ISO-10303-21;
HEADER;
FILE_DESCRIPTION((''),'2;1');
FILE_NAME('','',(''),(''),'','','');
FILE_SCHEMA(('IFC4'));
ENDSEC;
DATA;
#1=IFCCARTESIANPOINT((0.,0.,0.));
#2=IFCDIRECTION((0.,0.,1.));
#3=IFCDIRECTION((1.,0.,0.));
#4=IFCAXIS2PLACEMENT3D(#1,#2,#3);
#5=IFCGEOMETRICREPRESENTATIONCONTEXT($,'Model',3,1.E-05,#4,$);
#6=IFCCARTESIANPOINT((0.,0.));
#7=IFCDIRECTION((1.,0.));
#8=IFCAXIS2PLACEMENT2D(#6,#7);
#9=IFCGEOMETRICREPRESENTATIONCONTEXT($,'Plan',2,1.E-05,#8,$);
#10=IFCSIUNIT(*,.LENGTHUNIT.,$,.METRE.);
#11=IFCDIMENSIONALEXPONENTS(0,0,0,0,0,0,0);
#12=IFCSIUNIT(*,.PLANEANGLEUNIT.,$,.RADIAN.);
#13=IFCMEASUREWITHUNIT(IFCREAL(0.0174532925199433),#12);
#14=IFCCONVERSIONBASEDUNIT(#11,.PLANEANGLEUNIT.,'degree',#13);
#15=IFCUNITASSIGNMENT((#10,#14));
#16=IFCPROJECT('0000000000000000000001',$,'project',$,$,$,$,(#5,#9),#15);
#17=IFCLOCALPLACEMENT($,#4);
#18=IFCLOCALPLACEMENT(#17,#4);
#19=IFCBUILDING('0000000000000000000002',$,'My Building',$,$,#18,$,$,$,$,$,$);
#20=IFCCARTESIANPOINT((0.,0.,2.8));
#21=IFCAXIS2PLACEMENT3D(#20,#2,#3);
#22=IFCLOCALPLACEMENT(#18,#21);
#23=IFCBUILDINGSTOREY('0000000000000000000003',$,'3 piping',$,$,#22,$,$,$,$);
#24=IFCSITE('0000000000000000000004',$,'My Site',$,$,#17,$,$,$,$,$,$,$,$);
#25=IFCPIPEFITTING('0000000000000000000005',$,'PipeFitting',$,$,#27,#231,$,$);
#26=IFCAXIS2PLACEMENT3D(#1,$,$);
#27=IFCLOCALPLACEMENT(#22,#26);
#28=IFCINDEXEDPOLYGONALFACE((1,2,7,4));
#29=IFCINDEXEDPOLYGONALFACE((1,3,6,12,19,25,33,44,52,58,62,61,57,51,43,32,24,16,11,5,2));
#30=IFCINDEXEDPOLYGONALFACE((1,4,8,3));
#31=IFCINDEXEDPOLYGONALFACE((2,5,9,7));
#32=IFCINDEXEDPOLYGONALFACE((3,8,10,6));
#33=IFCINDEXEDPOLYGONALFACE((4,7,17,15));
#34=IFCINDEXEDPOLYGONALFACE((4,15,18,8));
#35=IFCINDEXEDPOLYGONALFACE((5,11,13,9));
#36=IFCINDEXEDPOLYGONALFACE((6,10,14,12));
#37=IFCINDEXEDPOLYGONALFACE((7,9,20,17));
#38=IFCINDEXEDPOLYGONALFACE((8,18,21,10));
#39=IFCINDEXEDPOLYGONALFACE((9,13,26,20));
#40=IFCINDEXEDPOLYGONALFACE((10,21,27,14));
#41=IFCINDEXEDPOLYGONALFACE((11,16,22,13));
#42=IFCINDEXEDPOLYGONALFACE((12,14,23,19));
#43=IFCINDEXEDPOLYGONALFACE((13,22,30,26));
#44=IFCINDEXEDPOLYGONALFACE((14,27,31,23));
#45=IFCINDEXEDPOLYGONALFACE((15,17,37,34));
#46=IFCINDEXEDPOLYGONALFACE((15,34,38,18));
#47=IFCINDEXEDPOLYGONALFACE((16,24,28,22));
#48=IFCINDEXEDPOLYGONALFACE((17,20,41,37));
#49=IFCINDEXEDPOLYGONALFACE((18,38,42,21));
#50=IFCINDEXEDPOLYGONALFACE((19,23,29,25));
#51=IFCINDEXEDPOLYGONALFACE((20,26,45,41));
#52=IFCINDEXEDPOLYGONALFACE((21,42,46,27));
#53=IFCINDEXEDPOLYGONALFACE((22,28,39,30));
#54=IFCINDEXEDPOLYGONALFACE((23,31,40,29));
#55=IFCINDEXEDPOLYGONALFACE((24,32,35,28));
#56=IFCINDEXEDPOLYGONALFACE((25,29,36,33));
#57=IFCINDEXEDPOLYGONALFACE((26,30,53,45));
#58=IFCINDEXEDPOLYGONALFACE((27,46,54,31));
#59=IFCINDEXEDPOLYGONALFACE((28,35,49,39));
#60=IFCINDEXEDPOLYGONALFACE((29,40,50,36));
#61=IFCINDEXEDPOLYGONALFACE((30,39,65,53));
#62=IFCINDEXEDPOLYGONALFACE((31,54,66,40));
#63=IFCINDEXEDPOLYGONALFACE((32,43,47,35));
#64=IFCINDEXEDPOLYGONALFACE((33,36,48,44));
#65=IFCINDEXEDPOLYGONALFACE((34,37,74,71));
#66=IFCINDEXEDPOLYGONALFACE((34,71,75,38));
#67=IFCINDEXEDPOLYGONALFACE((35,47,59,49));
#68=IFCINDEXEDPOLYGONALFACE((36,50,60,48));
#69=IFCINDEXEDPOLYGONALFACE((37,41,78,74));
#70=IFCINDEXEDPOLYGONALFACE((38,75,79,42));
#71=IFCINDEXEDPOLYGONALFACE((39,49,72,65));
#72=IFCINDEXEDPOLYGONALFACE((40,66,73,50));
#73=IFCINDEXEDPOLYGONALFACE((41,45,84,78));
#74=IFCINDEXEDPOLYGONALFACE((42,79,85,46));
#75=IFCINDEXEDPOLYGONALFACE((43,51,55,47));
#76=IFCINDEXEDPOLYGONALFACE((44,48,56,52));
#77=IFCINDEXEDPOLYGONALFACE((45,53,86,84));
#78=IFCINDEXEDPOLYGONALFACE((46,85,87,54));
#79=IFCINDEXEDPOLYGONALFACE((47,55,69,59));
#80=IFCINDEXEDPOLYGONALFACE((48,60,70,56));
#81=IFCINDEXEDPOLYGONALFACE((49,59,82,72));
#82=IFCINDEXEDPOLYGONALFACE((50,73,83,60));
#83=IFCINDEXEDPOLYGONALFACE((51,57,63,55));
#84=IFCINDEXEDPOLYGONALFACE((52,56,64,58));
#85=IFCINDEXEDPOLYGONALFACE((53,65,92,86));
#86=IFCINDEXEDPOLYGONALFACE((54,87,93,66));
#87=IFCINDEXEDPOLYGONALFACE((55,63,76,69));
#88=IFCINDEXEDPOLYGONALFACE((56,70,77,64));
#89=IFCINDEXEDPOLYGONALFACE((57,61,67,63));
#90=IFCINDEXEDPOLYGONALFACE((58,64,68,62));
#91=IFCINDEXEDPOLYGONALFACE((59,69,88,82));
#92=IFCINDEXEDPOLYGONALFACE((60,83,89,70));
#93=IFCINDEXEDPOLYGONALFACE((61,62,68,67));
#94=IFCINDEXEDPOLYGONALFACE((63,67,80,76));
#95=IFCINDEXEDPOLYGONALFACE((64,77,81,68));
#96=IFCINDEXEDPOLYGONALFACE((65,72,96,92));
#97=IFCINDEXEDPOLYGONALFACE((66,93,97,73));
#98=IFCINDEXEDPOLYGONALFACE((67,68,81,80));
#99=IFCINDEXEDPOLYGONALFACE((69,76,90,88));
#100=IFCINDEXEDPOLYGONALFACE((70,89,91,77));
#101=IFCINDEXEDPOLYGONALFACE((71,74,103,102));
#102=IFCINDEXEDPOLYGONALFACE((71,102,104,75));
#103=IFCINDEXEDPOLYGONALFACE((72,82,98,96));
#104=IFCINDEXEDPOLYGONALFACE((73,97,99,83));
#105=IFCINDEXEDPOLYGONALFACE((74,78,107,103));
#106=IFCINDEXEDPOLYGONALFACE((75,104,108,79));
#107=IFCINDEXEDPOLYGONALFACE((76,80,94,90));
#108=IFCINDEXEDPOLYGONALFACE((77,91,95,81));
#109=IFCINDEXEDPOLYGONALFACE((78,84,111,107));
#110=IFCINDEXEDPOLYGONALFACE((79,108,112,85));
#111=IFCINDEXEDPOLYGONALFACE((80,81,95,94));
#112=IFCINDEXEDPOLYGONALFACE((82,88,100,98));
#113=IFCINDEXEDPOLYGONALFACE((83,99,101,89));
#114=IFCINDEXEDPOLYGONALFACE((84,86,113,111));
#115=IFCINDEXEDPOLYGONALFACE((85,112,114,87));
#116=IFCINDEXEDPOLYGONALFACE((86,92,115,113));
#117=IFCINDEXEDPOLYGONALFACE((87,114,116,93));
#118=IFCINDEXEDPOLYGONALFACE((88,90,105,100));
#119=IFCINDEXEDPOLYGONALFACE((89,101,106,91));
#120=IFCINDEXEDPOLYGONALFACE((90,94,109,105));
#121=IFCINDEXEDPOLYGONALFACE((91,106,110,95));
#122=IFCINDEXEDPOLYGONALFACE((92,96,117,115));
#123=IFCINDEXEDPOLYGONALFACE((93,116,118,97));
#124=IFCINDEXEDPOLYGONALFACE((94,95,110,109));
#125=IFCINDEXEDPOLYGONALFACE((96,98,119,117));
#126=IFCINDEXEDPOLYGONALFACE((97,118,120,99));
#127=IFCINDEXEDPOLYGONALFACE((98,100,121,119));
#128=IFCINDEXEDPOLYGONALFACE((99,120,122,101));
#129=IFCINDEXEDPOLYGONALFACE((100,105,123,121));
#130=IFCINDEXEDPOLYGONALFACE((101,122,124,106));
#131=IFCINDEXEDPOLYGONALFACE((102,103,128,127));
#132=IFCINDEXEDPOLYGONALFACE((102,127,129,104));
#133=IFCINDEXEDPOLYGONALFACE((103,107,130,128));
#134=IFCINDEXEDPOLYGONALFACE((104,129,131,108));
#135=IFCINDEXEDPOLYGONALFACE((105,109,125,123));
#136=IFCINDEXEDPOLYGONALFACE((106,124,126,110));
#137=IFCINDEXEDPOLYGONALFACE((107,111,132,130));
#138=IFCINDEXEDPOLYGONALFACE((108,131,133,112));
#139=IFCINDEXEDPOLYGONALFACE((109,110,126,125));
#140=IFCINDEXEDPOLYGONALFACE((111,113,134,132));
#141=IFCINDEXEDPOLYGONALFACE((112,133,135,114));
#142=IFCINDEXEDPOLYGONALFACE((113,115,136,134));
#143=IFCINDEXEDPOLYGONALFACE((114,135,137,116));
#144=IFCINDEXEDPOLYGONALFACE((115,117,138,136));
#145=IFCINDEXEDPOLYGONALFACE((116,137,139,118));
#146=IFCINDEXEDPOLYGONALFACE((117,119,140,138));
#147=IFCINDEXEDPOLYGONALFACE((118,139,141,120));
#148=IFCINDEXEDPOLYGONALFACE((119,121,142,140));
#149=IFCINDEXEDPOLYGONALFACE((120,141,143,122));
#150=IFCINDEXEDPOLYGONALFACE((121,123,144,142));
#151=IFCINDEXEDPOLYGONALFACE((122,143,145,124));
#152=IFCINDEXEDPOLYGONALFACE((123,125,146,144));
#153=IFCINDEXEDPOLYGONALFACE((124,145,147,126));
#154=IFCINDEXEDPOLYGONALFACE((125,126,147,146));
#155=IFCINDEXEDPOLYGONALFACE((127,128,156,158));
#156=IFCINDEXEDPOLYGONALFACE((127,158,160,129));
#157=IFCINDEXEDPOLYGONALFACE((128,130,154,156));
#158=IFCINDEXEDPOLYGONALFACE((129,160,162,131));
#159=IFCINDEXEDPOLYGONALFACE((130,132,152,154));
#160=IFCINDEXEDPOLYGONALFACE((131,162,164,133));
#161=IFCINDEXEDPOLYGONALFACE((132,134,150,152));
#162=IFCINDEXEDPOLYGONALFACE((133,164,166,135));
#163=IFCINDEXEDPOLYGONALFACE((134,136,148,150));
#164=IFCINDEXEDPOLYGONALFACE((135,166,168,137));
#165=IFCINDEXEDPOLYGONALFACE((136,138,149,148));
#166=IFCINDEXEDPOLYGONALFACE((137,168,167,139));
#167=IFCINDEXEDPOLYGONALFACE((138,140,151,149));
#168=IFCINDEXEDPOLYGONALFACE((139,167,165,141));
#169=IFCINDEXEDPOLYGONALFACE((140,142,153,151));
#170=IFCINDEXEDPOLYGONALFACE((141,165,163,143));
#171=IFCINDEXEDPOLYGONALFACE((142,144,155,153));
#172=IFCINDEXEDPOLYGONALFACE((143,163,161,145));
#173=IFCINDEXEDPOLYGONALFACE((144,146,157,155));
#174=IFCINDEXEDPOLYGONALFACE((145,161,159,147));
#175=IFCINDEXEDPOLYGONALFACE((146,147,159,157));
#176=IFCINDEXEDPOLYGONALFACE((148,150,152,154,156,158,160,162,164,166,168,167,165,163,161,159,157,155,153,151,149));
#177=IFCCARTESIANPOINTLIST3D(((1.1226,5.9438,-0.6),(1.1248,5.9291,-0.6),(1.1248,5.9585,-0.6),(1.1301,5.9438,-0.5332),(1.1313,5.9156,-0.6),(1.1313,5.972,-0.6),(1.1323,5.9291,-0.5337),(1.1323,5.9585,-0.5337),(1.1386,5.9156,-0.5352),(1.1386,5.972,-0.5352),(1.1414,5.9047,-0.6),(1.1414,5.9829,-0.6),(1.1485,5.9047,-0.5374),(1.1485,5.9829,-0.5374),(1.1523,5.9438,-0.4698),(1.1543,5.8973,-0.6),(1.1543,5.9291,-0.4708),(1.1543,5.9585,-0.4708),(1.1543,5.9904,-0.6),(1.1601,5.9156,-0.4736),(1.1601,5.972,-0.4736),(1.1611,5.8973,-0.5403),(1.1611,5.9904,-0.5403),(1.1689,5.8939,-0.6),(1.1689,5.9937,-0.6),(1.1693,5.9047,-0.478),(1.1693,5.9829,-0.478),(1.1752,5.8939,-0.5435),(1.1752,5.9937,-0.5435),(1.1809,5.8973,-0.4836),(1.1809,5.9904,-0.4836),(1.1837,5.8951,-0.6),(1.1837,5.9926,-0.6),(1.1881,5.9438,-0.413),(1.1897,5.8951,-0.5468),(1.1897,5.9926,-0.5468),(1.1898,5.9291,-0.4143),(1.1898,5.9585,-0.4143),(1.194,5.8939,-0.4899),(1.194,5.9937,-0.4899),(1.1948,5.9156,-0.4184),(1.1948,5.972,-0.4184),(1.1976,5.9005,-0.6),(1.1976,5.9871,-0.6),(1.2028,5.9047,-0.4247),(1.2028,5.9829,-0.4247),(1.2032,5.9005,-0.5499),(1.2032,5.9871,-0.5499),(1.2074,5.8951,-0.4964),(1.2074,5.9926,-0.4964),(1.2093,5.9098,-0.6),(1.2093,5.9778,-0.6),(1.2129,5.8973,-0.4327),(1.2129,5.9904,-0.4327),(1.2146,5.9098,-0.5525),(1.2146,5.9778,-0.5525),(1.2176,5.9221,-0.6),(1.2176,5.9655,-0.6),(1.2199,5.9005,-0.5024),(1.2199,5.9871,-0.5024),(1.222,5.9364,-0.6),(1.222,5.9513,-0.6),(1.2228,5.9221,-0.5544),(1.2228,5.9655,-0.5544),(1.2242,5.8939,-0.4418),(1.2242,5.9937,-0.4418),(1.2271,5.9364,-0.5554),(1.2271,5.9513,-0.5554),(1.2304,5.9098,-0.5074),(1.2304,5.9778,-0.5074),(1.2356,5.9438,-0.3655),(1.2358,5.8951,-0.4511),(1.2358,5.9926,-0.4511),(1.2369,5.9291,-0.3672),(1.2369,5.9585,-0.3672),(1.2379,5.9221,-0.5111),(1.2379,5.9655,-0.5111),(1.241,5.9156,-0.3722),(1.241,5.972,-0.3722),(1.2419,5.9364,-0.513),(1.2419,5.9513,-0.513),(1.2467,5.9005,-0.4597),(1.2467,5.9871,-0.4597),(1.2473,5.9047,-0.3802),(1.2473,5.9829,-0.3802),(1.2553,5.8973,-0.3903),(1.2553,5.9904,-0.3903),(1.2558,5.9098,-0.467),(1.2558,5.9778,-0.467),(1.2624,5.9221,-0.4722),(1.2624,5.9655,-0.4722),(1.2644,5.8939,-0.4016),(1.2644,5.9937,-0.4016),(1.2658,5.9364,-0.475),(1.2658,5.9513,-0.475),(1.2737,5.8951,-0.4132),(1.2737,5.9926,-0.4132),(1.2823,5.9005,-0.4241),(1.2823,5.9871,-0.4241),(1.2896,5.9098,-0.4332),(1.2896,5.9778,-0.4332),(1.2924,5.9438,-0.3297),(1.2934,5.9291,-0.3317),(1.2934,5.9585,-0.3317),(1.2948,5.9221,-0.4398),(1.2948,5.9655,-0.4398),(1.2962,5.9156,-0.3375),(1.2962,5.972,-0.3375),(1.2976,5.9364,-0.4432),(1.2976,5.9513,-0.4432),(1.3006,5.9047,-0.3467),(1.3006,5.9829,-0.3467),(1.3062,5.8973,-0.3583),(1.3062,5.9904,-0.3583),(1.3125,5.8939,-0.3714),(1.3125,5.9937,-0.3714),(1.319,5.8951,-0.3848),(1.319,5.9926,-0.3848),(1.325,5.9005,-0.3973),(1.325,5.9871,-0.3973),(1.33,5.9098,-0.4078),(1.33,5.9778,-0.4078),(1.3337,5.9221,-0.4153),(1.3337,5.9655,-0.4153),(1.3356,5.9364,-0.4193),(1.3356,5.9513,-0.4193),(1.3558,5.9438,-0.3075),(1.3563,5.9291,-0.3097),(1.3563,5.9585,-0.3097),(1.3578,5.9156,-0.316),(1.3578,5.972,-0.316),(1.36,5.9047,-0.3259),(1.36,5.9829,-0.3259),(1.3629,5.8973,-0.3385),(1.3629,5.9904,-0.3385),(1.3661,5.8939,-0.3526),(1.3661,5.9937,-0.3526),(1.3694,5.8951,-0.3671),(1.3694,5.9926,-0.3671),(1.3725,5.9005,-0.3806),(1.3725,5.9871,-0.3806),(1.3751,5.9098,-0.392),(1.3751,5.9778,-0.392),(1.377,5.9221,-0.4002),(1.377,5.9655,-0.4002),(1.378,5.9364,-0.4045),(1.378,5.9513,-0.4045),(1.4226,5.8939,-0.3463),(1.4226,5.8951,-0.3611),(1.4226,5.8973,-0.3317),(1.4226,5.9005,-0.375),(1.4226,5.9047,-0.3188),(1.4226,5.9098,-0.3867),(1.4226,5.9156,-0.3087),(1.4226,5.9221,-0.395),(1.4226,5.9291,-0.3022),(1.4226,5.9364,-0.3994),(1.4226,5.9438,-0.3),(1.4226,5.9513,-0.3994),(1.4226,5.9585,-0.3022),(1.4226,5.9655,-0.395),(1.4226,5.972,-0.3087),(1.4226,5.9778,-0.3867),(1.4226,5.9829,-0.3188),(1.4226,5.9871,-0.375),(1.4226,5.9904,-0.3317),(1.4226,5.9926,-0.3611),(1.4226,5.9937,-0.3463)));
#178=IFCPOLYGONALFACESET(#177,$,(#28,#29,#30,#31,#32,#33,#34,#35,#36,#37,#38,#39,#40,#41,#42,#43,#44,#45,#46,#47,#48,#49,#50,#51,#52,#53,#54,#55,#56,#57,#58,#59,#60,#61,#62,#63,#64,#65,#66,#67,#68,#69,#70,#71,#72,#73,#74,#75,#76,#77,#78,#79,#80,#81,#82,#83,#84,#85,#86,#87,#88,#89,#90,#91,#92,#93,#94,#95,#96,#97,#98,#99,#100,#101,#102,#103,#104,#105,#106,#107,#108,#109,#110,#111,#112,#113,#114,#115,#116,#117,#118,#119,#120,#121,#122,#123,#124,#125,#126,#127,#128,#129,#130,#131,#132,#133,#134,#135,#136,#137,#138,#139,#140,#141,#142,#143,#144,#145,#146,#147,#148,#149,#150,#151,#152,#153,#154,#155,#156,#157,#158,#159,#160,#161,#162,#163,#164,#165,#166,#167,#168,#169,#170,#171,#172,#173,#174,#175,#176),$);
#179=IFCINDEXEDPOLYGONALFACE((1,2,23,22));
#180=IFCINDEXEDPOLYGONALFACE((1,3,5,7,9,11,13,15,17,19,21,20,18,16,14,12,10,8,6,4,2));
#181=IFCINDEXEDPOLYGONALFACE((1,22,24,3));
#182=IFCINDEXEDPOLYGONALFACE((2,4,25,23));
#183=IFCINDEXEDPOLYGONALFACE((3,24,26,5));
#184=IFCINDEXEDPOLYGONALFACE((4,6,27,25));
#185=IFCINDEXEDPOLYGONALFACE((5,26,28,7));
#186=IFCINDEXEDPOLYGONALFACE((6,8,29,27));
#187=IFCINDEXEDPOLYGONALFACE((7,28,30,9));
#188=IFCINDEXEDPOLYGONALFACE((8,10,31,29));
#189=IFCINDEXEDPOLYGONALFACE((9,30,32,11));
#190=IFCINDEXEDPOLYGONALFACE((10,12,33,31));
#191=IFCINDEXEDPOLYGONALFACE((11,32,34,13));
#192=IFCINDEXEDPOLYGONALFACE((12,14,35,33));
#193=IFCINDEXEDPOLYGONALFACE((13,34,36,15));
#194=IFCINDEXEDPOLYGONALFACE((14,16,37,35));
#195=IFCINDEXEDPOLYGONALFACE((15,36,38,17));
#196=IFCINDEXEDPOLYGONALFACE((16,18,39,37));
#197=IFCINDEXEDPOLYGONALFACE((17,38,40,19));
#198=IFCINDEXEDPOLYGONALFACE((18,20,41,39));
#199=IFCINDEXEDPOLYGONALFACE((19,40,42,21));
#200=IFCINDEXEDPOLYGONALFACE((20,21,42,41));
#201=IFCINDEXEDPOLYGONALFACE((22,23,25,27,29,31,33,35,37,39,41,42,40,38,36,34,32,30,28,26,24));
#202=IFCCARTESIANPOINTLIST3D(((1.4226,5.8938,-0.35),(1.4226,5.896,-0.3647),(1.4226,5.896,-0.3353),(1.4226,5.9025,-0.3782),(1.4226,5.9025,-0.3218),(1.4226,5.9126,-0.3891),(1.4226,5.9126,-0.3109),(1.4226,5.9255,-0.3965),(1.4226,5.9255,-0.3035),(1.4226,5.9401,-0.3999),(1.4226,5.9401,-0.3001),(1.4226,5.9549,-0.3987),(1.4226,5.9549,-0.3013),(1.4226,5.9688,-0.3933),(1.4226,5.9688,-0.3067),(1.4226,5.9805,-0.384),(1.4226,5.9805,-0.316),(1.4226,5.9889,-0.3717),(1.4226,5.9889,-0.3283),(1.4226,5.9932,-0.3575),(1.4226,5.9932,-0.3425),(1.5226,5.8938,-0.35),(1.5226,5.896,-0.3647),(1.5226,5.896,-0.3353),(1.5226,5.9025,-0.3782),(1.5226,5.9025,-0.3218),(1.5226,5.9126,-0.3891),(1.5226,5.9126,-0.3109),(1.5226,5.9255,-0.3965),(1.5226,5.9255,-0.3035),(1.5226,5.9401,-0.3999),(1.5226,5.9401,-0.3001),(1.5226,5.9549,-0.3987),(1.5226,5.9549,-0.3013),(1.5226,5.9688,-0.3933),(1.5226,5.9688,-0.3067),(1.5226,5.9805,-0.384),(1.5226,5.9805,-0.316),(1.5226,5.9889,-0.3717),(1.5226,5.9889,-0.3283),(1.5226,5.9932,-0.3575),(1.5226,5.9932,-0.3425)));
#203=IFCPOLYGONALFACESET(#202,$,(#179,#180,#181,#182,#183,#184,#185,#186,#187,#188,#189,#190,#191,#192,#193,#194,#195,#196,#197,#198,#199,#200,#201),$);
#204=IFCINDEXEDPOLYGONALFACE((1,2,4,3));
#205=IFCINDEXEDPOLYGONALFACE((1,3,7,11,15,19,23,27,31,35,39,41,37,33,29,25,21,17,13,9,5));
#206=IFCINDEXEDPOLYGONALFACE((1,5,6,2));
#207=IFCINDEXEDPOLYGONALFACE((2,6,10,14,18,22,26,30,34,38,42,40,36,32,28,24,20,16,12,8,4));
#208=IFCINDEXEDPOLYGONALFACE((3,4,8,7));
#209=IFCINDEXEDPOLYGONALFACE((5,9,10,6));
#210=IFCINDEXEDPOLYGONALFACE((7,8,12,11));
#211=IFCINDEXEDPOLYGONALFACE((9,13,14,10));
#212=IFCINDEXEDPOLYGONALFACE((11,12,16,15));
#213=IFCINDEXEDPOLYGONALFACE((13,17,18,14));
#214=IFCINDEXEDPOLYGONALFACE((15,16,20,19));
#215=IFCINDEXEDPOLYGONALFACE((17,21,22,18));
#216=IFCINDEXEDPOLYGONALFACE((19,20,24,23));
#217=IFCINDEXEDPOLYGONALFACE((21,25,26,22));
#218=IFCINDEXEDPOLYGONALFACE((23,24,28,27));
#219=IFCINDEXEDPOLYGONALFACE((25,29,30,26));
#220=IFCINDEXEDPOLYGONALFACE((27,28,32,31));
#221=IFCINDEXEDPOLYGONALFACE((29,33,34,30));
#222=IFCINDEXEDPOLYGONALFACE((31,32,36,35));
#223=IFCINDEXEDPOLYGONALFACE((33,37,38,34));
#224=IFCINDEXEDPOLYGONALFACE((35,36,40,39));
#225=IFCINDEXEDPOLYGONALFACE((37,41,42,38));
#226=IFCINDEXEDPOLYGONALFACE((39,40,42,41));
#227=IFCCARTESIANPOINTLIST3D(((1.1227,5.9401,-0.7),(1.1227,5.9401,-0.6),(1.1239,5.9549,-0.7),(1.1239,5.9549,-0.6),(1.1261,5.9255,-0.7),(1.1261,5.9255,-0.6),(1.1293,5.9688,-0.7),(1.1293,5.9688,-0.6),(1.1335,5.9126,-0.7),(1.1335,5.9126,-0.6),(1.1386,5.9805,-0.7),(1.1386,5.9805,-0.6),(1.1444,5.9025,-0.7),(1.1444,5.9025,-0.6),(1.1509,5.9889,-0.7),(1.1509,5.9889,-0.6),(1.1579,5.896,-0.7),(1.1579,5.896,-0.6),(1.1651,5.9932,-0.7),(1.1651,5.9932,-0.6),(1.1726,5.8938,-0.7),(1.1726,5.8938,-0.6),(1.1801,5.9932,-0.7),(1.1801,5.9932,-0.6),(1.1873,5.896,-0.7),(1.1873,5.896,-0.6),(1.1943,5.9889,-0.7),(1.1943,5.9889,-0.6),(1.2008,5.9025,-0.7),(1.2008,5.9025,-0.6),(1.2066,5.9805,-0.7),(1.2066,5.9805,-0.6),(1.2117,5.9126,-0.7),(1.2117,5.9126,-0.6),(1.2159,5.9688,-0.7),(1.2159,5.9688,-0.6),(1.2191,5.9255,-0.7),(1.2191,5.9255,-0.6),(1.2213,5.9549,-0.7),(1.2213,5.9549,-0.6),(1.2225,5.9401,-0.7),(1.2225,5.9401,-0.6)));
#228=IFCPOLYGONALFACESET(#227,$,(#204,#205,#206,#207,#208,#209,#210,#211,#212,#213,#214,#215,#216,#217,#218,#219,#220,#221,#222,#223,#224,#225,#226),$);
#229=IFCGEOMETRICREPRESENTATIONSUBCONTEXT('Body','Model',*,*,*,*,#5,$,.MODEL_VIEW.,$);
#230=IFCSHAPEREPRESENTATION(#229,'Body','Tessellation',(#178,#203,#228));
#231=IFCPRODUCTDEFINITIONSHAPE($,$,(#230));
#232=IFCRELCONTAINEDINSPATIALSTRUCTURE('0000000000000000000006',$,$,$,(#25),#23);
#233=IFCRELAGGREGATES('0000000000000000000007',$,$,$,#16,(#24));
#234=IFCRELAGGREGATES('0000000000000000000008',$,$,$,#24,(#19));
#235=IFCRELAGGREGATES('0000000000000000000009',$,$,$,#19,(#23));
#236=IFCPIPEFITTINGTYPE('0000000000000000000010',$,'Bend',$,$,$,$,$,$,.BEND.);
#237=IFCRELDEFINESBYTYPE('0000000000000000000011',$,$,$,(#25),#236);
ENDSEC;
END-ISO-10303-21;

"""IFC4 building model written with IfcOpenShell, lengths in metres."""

from ifc_helpers import new_model, entity, si_unit, converted_unit, frame, origin_with_axes, origin_2d_with_axis, place, context, subcontext, project, spatial, circle, extrude, source, transform, mapped, type_object, type_shapes, element, save


model = new_model("IFC4")

# Units and contexts
model_context = context("Model", 3, precision=1e-05, world=origin_with_axes())
plan_context = context("Plan", 2, precision=1e-05, world=origin_2d_with_axis())
body_context = subcontext(model_context, "Body", "Model", "MODEL_VIEW")
ifc_project = project(units=[si_unit("LENGTHUNIT", "METRE"), converted_unit("PLANEANGLEUNIT", "degree", entity("IfcReal", 0.0174532925199433), si_unit("PLANEANGLEUNIT", "RADIAN"), dimensions=[0, 0, 0, 0, 0, 0, 0])], contexts=[model_context, plan_context])

# Site, building, storey
site_placement = place(None, origin_with_axes())
site = spatial("IfcSite", under=ifc_project, at=site_placement, Name="My Site")
building_placement = place(site_placement, origin_with_axes())
building = spatial("IfcBuilding", under=site, at=building_placement, Name="My Building")
storey_placement = place(building_placement, frame((0.0, 0.0, 2.8), z_axis=(0.0, 0.0, 1.0), x_axis=(1.0, 0.0, 0.0)))
storey = spatial("IfcBuildingStorey", under=building, at=storey_placement, Name="3 piping")

# Pipe fitting
pipe_fitting_type_1 = type_object("IfcPipeFittingType", Name="Bend", PredefinedType="BEND")
shared_shape = source(origin_with_axes(), body_context, "Body", "SolidModel", [
    entity("IfcSweptDiskSolid", entity("IfcIndexedPolyCurve", entity("IfcCartesianPointList3D", [[0.0, 0.0, 0.1], [0.0, -0.0732, 0.2768], [0.0, -0.25, 0.35]]), [entity("IfcArcIndex", [1, 2, 3])]), 0.05),
    extrude(circle(Radius=0.05), origin_with_axes(), (0.0, 0.0, 1.0), 0.1),
    extrude(circle(Radius=0.05), frame((0.0, -0.25, 0.35), z_axis=(0.0, -1.0, 0.0), x_axis=(1.0, 0.0, 0.0)), (0.0, 0.0, 1.0), 0.1),
])
type_shapes(pipe_fitting_type_1, [shared_shape])
for number, where, z_axis, x_axis, name in (
    (1, (1.5226, 5.9438, -0.35), (-1.0, 0.0, 0.0), (0.0, -1.0, 0.0), "PipeFitting"),
):
    element("IfcPipeFitting", number, at=place(storey_placement, frame(where, z_axis=z_axis, x_axis=x_axis)), inside=storey, type_object=pipe_fitting_type_1, Name=name, context=body_context, shape_type="MappedRepresentation", body=[
        mapped(shared_shape, transform((0.0, 0.0, 0.0), x_axis=(1.0, 0.0, 0.0), y_axis=(0.0, 1.0, 0.0), z_axis=(0.0, 0.0, 1.0), scale=1.0)),
    ])

save(model, "model.ifc")
